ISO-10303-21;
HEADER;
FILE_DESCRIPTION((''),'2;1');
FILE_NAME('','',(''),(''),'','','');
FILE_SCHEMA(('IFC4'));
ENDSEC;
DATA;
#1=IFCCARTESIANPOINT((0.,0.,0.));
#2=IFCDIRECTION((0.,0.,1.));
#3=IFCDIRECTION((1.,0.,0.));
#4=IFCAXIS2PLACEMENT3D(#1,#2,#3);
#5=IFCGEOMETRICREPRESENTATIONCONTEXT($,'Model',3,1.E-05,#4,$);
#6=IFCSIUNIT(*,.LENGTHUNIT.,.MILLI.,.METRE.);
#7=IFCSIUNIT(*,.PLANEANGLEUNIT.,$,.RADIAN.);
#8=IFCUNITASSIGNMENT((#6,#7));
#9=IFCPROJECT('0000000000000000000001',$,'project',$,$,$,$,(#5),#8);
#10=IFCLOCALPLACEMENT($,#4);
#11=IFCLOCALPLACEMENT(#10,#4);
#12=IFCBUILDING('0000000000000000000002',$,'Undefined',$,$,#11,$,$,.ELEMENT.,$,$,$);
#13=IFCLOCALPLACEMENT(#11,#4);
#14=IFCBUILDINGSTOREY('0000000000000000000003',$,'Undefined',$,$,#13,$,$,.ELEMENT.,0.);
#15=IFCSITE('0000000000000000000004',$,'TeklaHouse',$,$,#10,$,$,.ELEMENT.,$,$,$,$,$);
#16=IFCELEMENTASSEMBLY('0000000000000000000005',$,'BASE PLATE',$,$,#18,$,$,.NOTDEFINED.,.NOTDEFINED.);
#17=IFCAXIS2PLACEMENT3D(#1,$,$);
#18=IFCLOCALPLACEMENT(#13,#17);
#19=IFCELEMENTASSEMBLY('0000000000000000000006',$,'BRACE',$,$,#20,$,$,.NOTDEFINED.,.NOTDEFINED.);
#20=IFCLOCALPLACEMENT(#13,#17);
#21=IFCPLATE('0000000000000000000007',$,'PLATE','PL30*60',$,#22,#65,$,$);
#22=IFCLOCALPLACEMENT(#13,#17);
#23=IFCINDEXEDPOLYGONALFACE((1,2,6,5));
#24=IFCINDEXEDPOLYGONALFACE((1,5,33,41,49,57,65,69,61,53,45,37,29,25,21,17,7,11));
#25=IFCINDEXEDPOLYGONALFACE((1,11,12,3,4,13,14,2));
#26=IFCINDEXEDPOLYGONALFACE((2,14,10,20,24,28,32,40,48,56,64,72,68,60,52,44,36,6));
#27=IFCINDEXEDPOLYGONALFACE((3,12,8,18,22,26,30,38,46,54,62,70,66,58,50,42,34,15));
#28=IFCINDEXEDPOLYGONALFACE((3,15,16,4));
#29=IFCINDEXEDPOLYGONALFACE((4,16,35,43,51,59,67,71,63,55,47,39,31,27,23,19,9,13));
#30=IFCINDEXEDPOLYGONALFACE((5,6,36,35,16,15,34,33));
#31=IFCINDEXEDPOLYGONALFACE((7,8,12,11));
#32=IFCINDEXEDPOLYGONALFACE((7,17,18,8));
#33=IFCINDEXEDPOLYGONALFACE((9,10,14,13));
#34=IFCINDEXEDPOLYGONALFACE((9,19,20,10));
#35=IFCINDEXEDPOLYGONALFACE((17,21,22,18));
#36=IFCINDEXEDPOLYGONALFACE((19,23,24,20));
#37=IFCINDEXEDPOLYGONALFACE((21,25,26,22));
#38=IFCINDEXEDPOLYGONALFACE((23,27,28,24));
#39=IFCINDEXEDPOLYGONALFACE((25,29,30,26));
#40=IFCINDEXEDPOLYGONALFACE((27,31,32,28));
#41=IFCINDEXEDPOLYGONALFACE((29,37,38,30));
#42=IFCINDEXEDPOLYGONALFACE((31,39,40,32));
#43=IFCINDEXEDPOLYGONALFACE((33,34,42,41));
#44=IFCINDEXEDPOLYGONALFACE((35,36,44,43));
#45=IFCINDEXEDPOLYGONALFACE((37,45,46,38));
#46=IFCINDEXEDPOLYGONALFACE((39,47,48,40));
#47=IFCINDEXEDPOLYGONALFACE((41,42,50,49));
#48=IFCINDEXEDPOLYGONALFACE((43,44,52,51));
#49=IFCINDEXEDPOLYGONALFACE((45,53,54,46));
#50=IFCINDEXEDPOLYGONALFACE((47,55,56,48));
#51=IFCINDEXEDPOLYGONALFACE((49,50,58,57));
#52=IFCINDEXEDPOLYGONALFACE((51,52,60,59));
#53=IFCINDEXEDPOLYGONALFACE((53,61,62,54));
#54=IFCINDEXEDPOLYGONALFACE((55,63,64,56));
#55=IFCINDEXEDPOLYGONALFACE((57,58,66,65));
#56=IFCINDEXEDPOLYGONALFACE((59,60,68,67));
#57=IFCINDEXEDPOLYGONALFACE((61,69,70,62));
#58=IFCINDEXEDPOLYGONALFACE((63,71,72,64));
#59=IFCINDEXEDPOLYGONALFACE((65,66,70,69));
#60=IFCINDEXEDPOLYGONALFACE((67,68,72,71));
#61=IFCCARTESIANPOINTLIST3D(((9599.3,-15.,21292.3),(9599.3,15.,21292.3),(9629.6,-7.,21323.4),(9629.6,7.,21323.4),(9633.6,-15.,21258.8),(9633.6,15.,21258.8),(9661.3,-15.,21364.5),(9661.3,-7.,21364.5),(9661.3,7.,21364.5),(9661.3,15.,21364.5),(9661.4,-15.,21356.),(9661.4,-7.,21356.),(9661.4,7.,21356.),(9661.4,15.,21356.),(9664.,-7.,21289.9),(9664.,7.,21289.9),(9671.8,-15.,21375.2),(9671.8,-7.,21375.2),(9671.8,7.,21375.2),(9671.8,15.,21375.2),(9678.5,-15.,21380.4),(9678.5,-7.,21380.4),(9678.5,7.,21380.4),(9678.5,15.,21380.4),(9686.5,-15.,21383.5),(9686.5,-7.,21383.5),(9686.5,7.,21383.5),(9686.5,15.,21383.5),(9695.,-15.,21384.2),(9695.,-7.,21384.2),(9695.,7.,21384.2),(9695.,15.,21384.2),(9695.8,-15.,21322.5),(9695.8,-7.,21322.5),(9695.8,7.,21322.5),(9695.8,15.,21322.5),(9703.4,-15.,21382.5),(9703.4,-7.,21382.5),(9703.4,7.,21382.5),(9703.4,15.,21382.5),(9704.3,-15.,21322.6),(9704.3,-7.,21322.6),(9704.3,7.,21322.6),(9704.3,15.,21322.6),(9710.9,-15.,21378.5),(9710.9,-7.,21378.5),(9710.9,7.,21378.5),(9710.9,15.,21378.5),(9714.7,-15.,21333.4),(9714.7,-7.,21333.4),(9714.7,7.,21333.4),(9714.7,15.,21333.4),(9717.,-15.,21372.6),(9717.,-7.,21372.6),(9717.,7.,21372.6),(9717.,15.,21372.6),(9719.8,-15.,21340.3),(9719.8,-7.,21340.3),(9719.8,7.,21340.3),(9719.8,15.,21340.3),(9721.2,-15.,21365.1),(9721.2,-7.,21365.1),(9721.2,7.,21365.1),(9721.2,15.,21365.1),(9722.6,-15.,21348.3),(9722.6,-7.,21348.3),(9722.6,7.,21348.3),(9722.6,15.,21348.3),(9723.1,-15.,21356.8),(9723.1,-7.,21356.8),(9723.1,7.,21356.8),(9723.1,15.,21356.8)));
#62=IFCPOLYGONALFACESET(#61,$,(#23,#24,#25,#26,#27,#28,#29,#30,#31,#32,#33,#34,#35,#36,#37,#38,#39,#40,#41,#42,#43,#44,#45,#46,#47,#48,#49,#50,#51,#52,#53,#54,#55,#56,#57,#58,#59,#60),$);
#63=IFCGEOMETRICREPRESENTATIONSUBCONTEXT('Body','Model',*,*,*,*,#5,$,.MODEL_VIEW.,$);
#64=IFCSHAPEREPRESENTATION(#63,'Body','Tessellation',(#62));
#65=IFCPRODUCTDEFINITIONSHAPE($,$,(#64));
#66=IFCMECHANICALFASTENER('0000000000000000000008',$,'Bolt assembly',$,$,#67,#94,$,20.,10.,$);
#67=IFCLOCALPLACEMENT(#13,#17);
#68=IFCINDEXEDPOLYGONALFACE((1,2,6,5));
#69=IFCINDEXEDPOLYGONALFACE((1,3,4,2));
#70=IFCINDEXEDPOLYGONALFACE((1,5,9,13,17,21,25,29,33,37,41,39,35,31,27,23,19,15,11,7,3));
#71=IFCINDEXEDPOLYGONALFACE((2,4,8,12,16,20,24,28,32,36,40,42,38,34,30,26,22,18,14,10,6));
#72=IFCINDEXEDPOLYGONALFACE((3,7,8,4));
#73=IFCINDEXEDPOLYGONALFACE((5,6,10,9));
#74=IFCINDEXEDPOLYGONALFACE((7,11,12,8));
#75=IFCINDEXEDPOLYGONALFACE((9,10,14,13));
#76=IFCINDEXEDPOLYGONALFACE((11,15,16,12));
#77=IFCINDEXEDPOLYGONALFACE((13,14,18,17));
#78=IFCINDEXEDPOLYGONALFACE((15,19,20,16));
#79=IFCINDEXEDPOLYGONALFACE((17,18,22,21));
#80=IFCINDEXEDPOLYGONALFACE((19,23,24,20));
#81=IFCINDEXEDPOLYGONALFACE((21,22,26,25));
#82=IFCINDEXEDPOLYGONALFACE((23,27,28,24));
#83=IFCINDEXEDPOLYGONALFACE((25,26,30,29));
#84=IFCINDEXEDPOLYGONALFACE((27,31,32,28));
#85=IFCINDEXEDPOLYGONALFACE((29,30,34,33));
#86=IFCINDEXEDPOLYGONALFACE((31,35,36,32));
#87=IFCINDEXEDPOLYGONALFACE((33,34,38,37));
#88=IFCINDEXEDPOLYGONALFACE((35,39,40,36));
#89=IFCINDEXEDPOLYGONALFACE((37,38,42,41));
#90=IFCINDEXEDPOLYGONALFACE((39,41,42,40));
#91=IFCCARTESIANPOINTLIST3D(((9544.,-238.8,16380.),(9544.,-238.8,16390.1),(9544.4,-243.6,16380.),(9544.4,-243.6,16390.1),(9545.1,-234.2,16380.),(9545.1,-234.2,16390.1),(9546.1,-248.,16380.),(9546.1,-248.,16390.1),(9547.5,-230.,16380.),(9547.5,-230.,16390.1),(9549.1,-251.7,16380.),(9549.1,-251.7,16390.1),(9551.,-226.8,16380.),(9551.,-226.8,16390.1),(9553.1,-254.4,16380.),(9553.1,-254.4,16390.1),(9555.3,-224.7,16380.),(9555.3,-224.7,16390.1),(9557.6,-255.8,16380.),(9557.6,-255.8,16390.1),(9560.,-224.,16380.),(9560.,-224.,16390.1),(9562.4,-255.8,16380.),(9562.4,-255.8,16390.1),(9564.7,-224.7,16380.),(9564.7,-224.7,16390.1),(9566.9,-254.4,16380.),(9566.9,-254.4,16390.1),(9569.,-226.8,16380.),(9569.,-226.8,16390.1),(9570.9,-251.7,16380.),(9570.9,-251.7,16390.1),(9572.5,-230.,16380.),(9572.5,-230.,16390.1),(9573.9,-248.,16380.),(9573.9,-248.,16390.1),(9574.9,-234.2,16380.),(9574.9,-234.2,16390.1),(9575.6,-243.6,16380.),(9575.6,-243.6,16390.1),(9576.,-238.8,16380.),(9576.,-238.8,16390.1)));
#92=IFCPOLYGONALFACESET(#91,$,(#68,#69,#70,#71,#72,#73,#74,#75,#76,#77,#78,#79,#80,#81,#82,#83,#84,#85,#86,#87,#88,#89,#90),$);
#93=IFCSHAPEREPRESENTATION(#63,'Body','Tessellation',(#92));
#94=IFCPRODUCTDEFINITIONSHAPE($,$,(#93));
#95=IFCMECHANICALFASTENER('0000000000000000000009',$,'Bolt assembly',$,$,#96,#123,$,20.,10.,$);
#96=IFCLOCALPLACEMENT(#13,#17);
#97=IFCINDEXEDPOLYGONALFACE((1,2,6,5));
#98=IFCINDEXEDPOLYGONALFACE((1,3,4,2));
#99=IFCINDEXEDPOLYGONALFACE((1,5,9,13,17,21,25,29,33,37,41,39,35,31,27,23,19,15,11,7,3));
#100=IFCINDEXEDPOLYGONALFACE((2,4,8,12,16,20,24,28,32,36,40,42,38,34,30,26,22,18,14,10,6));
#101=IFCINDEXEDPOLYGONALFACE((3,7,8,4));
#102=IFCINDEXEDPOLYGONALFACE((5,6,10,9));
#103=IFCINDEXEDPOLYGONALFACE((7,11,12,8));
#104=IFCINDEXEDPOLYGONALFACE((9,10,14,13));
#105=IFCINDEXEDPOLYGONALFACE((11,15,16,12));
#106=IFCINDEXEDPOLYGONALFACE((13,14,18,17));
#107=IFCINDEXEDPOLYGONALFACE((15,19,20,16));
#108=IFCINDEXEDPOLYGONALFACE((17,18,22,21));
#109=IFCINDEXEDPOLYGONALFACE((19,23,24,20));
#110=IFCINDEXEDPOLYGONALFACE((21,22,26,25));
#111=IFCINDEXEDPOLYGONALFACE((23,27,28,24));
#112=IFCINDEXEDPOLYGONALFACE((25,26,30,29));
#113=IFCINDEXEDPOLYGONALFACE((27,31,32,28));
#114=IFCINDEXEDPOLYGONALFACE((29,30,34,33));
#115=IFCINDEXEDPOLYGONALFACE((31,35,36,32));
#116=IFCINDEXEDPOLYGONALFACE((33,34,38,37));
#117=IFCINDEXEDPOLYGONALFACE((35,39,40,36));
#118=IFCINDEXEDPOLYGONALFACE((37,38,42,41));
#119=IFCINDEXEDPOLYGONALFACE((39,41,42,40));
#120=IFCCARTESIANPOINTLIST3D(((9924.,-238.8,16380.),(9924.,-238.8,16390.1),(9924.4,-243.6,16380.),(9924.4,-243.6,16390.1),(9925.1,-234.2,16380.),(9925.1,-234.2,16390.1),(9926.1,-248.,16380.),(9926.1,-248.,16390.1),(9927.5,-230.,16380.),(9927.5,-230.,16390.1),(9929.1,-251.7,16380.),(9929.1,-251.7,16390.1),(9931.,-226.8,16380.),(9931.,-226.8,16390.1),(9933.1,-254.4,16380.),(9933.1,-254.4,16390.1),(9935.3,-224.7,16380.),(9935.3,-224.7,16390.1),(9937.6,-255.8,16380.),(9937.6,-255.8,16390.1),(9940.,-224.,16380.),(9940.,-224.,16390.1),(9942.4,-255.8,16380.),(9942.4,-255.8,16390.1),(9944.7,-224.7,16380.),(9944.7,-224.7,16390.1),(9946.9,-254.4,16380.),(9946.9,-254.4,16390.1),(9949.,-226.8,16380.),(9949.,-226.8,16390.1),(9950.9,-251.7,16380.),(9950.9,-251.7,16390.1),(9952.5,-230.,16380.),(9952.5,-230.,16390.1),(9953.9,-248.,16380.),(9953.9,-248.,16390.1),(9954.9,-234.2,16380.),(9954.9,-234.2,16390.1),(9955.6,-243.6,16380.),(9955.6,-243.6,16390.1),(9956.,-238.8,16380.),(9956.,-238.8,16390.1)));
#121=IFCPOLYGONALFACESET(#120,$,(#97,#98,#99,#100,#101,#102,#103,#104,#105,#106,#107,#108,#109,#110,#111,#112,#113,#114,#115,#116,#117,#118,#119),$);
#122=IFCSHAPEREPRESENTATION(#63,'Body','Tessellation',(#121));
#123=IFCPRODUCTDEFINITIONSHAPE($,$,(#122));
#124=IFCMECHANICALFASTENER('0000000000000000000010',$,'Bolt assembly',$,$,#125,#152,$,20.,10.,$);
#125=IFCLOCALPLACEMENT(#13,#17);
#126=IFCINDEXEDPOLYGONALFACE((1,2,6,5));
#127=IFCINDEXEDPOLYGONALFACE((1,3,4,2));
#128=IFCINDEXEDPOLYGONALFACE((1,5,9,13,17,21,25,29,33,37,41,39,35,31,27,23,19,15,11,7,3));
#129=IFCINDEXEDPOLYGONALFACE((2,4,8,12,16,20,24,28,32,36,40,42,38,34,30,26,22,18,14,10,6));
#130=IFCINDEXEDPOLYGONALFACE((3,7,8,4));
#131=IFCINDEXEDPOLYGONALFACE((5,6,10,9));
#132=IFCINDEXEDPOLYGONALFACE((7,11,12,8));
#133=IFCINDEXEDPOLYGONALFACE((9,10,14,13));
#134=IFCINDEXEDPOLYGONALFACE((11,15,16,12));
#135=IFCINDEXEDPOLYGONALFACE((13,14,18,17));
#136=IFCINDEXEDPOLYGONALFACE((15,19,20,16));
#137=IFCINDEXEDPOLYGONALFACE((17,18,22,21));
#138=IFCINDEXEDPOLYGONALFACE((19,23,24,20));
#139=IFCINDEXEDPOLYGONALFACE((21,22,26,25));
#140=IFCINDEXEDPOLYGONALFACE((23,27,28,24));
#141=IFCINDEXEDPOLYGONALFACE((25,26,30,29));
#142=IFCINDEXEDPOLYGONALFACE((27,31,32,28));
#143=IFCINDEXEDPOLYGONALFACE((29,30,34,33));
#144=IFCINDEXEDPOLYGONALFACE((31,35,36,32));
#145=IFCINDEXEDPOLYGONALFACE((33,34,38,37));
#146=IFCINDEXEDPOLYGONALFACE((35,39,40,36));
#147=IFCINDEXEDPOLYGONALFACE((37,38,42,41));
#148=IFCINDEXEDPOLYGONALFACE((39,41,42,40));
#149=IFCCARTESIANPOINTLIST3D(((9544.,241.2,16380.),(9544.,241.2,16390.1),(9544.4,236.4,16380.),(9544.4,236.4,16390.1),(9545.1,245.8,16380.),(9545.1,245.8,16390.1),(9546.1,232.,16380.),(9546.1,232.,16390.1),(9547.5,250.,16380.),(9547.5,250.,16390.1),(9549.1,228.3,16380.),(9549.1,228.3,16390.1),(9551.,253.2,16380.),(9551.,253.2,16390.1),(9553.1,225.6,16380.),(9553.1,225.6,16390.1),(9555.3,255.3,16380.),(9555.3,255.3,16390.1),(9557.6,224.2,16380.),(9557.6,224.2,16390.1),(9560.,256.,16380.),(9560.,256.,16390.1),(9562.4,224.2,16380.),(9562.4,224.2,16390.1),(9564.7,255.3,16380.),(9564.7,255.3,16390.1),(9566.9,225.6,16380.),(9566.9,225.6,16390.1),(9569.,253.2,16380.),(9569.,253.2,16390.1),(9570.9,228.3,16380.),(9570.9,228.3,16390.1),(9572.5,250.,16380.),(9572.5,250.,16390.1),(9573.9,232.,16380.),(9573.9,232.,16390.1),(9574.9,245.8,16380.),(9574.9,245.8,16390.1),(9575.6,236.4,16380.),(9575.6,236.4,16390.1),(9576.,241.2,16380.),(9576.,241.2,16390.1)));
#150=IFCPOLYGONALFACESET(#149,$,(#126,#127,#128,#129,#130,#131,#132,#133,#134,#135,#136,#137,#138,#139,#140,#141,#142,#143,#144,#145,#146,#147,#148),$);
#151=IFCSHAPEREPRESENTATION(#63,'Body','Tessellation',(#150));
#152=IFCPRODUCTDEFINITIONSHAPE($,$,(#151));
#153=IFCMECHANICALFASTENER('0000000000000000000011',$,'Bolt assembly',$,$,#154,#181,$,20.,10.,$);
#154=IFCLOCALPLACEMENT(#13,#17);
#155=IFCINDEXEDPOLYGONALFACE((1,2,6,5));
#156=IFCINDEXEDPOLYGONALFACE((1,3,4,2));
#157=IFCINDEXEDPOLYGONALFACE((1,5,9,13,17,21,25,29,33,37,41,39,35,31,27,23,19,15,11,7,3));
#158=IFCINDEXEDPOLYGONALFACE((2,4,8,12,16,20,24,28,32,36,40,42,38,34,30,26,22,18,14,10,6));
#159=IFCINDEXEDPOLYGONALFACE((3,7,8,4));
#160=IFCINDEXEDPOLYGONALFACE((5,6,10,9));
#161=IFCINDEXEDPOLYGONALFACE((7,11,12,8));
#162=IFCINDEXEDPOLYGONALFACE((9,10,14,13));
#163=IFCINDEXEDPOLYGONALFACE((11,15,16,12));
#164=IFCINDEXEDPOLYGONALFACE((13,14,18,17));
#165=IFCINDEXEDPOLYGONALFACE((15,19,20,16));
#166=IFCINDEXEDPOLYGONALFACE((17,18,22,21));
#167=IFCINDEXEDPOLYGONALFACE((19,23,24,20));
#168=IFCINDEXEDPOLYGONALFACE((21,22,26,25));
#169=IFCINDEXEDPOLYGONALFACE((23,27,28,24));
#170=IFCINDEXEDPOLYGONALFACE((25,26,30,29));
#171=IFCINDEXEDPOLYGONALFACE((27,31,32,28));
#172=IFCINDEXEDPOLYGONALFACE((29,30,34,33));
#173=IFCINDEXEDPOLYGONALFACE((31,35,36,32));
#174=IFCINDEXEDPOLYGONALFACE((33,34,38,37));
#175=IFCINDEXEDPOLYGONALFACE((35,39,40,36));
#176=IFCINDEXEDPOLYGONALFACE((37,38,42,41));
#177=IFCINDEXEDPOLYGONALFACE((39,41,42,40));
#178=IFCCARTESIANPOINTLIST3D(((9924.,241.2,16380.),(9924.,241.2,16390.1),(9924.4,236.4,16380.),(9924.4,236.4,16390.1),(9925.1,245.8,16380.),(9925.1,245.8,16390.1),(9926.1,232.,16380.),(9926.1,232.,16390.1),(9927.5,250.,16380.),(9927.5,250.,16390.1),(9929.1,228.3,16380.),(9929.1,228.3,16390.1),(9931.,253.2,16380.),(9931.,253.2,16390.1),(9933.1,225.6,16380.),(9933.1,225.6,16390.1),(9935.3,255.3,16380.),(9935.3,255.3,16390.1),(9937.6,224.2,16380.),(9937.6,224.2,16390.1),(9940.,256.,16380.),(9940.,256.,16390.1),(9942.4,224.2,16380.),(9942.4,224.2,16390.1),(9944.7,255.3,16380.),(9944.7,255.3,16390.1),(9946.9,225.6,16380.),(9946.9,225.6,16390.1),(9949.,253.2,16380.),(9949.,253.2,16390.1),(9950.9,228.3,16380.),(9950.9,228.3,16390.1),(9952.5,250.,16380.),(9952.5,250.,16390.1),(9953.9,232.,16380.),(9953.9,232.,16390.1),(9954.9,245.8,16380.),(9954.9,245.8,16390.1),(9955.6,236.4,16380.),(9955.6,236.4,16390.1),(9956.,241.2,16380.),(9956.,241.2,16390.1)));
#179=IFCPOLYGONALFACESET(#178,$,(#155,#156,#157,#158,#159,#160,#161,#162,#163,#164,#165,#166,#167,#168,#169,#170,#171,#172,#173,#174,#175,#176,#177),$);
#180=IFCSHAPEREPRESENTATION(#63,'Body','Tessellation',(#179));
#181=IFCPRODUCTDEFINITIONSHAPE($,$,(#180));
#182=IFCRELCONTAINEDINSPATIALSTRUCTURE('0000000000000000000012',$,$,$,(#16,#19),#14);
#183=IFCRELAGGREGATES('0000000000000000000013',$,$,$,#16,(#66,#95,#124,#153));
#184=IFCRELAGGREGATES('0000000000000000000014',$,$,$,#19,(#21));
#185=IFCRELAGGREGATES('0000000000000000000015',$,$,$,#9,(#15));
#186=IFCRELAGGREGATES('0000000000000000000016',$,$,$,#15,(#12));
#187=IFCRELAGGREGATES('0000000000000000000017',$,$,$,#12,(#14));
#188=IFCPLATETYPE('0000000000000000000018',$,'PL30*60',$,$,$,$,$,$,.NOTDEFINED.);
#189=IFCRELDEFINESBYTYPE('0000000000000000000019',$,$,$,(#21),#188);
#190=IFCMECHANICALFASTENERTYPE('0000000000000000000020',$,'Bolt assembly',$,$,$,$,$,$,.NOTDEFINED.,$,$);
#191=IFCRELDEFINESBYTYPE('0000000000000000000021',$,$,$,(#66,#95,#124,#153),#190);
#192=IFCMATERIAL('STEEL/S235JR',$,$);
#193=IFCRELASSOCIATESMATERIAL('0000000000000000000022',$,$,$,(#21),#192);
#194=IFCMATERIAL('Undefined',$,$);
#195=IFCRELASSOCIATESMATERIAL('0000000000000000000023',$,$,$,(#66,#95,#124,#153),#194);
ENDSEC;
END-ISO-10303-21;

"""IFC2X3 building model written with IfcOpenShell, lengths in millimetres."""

from ifc_helpers import new_model, si_unit, frame, frame_2d, origin_with_axes, origin_2d_with_axis, place, context, subcontext, project, spatial, polyline, circle_curve, parameter, trimmed, segment, composite_curve, rectangle, circle, outline, extrude, boolean, source, transform, mapped, material, type_object, element, aggregate, save


model = new_model("IFC2X3")

# Units and contexts
model_context = context("Model", 3, precision=1e-05, world=origin_with_axes())
body_context = subcontext(model_context, "Body", "Model", "MODEL_VIEW")
ifc_project = project(units=[si_unit("LENGTHUNIT", "METRE", prefix="MILLI"), si_unit("PLANEANGLEUNIT", "RADIAN")], contexts=[model_context])

# Site, building, storey
site_placement = place(None, origin_with_axes())
site = spatial("IfcSite", under=ifc_project, at=site_placement, Name="TeklaHouse", CompositionType="ELEMENT")
building_placement = place(site_placement, origin_with_axes())
building = spatial("IfcBuilding", under=site, at=building_placement, Name="Undefined", CompositionType="ELEMENT")
storey_placement = place(building_placement, origin_with_axes())
storey = spatial("IfcBuildingStorey", under=building, at=storey_placement, Name="Undefined", CompositionType="ELEMENT", Elevation=0.0)

# Element assembly
assembly_1_placement = place(storey_placement, origin_with_axes())
assembly_1 = element("IfcElementAssembly", 1, at=assembly_1_placement, inside=storey, Name="BASE PLATE", AssemblyPlace="NOTDEFINED", PredefinedType="NOTDEFINED")
ifc_material_1 = material(Name="STEEL/S235JR")

# Shared definitions
plate_type_1 = type_object("IfcPlateType", Name="PL30*60", PredefinedType="NOTDEFINED")

# Element assembly, plate
assembly_2_placement = place(storey_placement, origin_with_axes())
assembly_2 = element("IfcElementAssembly", 2, at=assembly_2_placement, inside=storey, Name="BRACE", AssemblyPlace="NOTDEFINED", PredefinedType="NOTDEFINED")
plate_1_placement = place(assembly_2_placement, frame((9735.7, 0.0, 21354.8), z_axis=(0.0, -1.0, 0.0), x_axis=(-0.716, 0.0, 0.6981)))
plate_1 = element("IfcPlate", 3, at=plate_1_placement, type_object=plate_type_1, material=ifc_material_1, Name="PLATE", Description="PL30*60", context=body_context, shape_type="CSG", body=[
    boolean("DIFFERENCE", extrude(outline(composite_curve([segment(trimmed(circle_curve(frame_2d((30.0, 30.0), x_axis=(-1.0, 0.0)), 30.0), [parameter(0.0)], [parameter(1.570796)], True, "PARAMETER"), True, "CONTINUOUS"), segment(trimmed(circle_curve(frame_2d((30.0, 30.0), x_axis=(0.0, -1.0)), 30.0), [parameter(0.0)], [parameter(1.570796)], True, "PARAMETER"), True, "CONTINUOUS"), segment(polyline([(60.0, 30.0), (60.0, 45.0), (54.0, 51.0), (54.0, 140.0), (6.0, 140.0), (6.0, 51.0), (0.0, 45.0), (0.0, 30.0)]), True, "CONTINUOUS")], self_intersect=True)), frame((0.0, 0.0, -15.0), z_axis=(0.0, 0.0, 1.0), x_axis=(1.0, 0.0, 0.0)), (0.0, 0.0, 1.0), 30.0), extrude(rectangle(XDim=14.0, YDim=70.0, at=origin_2d_with_axis()), frame((30.0, 96.6, 0.0), z_axis=(0.0, -1.0, 0.0), x_axis=(0.0, 0.0, -1.0)), (0.0, 0.0, 1.0), 106.6)),
])

# Mechanical fasteners
ifc_material_2 = material(Name="Undefined")
mechanical_fastener_type = type_object("IfcMechanicalFastenerType", Name="Bolt assembly")
shared_shape_1 = source(origin_with_axes(), body_context, "Body", "SweptSolid", [
    extrude(circle(Radius=16.0, at=origin_2d_with_axis()), frame((0.0, 0.0, 0.0), z_axis=(0.0, 1.0, 0.0), x_axis=(1.0, 0.0, 0.0)), (0.0, 0.0, 1.0), 10.1),
])
mechanical_fastener_1_placement = place(assembly_1_placement, frame((9560.0, -240.0, 16380.0), z_axis=(1.0, 0.0, 0.0), x_axis=(0.0, 1.0, 0.0)))
mechanical_fastener_1 = element("IfcMechanicalFastener", 4, at=mechanical_fastener_1_placement, type_object=mechanical_fastener_type, material=ifc_material_2, Name="Bolt assembly", NominalDiameter=20.0, NominalLength=10.0, context=body_context, shape_type="MappedRepresentation", body=[
    mapped(shared_shape_1, transform((0.0, 0.0, 0.0))),
])
mechanical_fastener_2_placement = place(assembly_1_placement, frame((9940.0, -240.0, 16380.0), z_axis=(1.0, 0.0, 0.0), x_axis=(0.0, 1.0, 0.0)))
mechanical_fastener_2 = element("IfcMechanicalFastener", 5, at=mechanical_fastener_2_placement, type_object=mechanical_fastener_type, material=ifc_material_2, Name="Bolt assembly", NominalDiameter=20.0, NominalLength=10.0, context=body_context, shape_type="MappedRepresentation", body=[
    mapped(shared_shape_1, transform((0.0, 0.0, 0.0))),
])
mechanical_fastener_3_placement = place(assembly_1_placement, frame((9560.0, 240.0, 16380.0), z_axis=(1.0, 0.0, 0.0), x_axis=(0.0, 1.0, 0.0)))
mechanical_fastener_3 = element("IfcMechanicalFastener", 6, at=mechanical_fastener_3_placement, type_object=mechanical_fastener_type, material=ifc_material_2, Name="Bolt assembly", NominalDiameter=20.0, NominalLength=10.0, context=body_context, shape_type="MappedRepresentation", body=[
    mapped(shared_shape_1, transform((0.0, 0.0, 0.0))),
])
mechanical_fastener_4_placement = place(assembly_1_placement, frame((9940.0, 240.0, 16380.0), z_axis=(1.0, 0.0, 0.0), x_axis=(0.0, 1.0, 0.0)))
mechanical_fastener_4 = element("IfcMechanicalFastener", 7, at=mechanical_fastener_4_placement, type_object=mechanical_fastener_type, material=ifc_material_2, Name="Bolt assembly", NominalDiameter=20.0, NominalLength=10.0, context=body_context, shape_type="MappedRepresentation", body=[
    mapped(shared_shape_1, transform((0.0, 0.0, 0.0))),
])
aggregate(assembly_1, [mechanical_fastener_1, mechanical_fastener_2, mechanical_fastener_3, mechanical_fastener_4])

aggregate(assembly_2, [plate_1])

save(model, "model.ifc")
